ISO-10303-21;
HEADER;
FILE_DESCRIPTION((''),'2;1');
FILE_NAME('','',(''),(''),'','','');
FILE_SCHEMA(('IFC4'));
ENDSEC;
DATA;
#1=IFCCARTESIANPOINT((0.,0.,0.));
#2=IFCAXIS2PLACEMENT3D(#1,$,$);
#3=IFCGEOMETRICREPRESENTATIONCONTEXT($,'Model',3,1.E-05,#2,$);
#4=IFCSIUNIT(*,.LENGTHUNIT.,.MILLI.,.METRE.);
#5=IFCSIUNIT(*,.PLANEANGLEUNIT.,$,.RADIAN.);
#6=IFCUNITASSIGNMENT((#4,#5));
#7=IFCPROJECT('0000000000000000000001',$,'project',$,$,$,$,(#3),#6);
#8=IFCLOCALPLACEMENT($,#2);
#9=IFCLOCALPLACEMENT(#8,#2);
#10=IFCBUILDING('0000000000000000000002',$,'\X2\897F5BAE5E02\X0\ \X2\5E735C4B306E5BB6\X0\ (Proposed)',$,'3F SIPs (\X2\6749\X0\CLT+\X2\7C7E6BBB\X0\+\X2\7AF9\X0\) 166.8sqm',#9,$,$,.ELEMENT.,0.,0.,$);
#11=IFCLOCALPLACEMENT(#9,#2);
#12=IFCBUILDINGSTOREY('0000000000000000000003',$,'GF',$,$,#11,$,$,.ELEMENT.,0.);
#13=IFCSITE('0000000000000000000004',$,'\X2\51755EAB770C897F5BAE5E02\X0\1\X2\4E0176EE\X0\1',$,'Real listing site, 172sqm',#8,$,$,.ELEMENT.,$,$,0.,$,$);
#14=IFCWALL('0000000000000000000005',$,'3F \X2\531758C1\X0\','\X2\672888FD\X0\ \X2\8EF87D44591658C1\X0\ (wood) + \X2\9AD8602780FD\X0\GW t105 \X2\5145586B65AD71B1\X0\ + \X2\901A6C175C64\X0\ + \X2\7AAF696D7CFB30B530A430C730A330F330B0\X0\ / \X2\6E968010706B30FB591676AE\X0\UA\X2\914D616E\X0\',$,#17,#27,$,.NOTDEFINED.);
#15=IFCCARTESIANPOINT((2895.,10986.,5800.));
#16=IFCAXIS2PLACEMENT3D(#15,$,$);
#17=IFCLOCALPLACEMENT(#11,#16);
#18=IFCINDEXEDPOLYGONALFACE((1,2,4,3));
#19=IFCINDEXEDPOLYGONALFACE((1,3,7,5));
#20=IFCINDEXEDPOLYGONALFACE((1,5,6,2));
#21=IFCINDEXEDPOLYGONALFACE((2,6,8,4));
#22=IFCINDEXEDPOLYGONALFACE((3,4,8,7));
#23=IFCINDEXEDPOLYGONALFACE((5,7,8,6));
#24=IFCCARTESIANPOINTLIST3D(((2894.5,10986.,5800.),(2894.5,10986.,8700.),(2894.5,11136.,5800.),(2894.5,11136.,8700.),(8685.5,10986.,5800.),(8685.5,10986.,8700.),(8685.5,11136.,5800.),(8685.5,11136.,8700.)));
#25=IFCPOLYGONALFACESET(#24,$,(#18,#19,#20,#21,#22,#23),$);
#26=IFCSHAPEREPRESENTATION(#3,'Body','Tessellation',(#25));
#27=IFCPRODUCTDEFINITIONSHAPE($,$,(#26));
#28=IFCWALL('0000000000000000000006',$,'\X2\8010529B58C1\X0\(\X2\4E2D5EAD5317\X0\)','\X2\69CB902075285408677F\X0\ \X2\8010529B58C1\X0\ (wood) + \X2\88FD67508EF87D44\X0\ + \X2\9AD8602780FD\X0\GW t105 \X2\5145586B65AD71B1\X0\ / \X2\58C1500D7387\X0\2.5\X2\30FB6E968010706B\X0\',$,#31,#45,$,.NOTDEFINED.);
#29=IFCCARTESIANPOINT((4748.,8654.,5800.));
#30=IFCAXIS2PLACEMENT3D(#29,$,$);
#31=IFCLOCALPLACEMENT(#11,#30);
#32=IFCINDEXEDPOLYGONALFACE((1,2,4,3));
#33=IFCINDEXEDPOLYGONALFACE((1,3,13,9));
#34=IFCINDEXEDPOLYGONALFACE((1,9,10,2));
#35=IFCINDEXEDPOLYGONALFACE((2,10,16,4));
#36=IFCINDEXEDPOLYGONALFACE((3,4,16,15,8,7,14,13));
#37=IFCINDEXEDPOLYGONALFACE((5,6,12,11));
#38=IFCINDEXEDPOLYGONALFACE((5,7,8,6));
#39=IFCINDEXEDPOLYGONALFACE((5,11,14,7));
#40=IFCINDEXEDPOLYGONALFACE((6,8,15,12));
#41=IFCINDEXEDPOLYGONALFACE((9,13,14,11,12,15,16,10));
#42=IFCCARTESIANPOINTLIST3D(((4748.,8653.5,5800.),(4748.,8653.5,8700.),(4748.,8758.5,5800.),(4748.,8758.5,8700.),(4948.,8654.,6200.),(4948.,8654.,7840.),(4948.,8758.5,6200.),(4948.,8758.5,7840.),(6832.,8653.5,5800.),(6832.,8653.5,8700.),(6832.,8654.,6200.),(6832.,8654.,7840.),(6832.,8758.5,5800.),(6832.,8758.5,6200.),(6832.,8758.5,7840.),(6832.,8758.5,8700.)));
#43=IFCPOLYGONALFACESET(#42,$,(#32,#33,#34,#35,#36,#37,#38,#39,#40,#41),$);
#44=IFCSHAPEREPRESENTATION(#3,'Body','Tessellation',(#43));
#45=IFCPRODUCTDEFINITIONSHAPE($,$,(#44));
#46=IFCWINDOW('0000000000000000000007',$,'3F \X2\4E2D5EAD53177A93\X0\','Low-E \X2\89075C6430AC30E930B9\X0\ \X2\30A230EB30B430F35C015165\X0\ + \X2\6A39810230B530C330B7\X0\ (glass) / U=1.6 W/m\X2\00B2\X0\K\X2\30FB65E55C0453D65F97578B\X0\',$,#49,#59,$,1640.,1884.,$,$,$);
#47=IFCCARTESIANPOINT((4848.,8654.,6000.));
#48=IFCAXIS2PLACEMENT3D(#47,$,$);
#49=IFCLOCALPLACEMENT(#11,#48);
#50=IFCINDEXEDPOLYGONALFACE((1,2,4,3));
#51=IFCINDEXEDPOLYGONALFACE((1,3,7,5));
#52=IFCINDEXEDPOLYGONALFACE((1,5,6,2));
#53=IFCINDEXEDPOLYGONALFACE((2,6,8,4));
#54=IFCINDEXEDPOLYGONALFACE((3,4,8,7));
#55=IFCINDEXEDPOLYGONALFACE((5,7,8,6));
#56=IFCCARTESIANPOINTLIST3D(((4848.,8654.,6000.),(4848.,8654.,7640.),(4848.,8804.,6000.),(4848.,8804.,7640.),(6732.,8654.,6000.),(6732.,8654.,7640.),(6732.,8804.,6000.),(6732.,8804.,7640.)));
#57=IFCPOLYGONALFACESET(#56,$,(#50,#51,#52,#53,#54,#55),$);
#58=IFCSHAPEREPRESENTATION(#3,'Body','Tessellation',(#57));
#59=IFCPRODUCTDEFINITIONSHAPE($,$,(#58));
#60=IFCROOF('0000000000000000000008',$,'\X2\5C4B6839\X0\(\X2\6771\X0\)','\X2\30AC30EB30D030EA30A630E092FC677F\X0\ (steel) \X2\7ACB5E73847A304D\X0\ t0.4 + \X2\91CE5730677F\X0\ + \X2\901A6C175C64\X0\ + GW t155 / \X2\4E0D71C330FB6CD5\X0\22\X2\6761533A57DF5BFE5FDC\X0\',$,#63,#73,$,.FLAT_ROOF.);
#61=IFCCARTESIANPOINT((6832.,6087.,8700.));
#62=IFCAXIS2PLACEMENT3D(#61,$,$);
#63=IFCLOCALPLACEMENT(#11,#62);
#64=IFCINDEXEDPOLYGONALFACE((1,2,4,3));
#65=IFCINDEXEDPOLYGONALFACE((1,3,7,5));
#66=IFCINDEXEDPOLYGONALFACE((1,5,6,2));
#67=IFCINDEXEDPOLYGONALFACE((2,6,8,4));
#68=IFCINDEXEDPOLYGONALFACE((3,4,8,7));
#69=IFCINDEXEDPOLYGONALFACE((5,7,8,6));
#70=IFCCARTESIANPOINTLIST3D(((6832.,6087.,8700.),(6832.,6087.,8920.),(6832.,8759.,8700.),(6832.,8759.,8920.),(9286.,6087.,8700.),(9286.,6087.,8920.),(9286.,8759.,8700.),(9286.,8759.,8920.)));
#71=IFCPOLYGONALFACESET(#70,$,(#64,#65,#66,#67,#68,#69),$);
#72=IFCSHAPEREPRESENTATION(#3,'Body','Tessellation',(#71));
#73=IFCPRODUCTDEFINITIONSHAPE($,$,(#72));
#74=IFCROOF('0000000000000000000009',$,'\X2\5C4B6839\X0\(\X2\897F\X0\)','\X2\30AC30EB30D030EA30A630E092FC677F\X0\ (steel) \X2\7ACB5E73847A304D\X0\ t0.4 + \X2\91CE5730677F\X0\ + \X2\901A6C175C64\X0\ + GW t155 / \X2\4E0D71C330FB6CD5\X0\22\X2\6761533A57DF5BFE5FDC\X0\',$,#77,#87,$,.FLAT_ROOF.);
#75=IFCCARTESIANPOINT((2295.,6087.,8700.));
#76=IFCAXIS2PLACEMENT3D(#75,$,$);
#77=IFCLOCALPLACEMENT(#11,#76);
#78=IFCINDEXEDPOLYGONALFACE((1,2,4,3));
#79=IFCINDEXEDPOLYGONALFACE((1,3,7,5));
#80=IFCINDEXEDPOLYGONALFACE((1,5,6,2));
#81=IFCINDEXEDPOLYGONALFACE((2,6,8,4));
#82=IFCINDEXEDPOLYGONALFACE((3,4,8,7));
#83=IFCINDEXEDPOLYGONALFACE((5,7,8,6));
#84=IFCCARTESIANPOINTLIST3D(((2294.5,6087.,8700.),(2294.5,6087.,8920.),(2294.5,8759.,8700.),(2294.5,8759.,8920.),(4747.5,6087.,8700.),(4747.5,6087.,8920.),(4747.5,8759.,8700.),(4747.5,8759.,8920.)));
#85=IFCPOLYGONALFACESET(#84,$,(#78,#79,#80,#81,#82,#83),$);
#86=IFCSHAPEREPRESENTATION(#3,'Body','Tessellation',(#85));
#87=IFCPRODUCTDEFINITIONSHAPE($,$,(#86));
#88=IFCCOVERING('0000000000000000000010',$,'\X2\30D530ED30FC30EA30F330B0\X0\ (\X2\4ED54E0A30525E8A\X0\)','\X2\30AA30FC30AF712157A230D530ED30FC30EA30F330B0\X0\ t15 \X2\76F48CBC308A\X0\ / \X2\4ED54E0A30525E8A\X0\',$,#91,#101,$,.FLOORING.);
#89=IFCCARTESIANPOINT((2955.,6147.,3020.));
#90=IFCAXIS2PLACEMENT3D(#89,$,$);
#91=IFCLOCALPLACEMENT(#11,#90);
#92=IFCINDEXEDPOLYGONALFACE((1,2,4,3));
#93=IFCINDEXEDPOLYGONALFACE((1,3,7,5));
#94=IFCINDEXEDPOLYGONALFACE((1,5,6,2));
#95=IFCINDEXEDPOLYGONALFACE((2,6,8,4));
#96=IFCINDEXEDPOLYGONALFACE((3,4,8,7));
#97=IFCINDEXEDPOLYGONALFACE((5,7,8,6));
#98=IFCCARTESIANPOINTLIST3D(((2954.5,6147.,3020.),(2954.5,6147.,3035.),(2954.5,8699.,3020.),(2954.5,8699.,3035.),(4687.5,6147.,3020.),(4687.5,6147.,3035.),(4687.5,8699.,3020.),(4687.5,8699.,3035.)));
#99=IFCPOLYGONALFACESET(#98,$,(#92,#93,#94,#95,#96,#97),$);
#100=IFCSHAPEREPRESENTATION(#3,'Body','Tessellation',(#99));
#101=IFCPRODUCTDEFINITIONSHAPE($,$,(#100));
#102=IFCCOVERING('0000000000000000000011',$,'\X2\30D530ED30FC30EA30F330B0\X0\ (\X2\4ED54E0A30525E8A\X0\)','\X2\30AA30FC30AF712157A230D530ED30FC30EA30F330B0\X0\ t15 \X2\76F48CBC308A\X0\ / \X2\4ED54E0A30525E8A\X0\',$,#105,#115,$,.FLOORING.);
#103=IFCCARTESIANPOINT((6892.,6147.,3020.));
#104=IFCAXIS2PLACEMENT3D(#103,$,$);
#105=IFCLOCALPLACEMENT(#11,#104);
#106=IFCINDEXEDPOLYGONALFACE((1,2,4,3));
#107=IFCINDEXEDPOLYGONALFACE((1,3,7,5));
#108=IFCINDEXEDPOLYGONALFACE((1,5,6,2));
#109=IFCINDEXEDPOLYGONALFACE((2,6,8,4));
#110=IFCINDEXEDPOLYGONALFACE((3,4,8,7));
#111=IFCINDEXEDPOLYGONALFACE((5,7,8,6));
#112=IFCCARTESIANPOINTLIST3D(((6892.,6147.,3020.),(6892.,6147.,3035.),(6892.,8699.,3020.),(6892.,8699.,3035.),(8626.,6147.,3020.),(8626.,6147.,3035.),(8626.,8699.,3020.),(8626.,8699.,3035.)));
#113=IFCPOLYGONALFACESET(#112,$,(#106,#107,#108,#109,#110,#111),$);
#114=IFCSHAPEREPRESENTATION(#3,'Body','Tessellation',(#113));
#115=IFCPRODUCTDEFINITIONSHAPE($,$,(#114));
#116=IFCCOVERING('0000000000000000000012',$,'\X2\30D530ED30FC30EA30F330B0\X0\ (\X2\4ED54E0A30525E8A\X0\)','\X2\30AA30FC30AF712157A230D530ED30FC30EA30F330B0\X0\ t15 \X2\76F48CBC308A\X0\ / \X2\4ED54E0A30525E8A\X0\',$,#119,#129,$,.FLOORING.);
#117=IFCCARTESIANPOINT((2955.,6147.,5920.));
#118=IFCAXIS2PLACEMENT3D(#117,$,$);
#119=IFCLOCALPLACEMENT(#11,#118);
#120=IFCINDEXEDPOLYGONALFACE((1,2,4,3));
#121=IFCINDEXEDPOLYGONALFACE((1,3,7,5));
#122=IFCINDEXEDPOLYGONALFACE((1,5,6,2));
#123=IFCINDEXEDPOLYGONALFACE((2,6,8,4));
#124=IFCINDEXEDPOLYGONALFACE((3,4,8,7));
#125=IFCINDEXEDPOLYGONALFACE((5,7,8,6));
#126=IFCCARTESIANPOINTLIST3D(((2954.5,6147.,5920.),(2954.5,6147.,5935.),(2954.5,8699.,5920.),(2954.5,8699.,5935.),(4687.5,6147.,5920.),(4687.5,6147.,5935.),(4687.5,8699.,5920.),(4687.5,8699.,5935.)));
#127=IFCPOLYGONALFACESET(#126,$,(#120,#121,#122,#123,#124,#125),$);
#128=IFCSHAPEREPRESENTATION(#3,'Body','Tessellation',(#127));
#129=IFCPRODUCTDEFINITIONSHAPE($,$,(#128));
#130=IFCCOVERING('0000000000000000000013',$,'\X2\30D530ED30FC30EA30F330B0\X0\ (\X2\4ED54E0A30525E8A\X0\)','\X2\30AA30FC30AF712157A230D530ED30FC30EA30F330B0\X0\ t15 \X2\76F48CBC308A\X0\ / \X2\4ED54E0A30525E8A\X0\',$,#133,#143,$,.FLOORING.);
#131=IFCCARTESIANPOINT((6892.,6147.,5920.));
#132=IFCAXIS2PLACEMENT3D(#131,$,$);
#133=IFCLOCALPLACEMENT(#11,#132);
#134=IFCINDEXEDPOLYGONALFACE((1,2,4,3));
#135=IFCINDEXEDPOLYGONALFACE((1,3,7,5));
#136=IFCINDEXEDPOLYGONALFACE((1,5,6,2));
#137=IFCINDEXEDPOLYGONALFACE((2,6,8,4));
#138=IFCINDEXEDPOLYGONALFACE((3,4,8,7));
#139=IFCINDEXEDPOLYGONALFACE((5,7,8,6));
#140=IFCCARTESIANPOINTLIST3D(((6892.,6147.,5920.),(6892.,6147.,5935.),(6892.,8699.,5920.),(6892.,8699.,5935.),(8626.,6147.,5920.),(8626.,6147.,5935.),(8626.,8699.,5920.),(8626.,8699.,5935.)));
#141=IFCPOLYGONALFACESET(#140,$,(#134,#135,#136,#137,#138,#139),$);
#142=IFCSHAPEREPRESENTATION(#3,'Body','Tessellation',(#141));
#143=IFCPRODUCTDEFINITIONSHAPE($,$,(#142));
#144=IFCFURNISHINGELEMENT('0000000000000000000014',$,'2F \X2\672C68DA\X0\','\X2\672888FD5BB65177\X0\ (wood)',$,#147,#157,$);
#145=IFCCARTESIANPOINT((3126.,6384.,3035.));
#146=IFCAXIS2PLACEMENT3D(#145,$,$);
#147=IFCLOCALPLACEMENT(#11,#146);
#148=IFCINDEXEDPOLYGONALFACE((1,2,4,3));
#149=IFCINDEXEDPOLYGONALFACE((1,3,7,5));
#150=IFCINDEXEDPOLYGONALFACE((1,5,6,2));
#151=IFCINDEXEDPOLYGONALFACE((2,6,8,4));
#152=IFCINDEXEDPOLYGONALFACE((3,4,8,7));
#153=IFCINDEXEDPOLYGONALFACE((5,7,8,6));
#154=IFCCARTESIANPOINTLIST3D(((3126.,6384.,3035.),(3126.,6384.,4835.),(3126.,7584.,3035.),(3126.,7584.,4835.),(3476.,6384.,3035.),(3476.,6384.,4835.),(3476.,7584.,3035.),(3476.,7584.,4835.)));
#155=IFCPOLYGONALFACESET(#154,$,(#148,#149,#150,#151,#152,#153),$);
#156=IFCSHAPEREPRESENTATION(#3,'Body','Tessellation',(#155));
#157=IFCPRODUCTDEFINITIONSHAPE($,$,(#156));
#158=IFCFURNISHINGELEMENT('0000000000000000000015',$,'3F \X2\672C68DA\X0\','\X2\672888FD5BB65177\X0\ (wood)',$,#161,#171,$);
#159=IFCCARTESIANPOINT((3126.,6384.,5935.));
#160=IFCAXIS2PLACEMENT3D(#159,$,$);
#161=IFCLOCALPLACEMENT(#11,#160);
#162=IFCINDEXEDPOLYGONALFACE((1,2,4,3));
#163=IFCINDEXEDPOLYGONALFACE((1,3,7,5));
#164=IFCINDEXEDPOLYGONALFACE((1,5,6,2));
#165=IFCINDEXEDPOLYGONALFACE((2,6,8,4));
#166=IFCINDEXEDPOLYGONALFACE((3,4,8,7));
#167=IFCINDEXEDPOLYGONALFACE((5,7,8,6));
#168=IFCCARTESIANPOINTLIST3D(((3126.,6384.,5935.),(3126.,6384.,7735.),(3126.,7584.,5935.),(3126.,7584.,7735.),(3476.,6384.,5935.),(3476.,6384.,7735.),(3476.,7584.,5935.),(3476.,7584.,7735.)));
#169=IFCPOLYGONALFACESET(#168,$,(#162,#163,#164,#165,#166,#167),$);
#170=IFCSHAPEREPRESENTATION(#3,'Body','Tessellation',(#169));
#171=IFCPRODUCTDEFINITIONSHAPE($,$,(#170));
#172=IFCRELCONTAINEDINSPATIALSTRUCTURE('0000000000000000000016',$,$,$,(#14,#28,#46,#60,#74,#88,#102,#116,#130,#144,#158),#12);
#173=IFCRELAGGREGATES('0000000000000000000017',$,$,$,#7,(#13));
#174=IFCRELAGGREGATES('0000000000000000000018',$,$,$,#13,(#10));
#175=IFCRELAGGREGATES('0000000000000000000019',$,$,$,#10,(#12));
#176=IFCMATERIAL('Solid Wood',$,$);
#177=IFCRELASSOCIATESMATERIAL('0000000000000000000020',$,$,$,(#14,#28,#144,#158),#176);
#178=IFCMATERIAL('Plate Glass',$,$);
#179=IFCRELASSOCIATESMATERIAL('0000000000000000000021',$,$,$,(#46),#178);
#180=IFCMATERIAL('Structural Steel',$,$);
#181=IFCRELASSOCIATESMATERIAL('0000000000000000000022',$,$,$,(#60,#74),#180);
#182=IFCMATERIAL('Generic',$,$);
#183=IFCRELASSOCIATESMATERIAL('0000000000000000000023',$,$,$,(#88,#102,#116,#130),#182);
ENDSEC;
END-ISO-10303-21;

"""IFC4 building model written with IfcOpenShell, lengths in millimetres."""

from ifc_helpers import new_model, si_unit, frame, frame_2d, origin, place, context, project, spatial, rectangle, extrude, material, element, fill, save


model = new_model("IFC4")

# Units and contexts
model_context = context("Model", 3, precision=1e-05, world=origin())
ifc_project = project(units=[si_unit("LENGTHUNIT", "METRE", prefix="MILLI"), si_unit("PLANEANGLEUNIT", "RADIAN")], contexts=[model_context])

# Site, building, storey
site_placement = place(None, origin())
site = spatial("IfcSite", under=ifc_project, at=site_placement, Name="兵庫県西宮市1丁目1", ObjectType="Real listing site, 172sqm", CompositionType="ELEMENT", RefElevation=0.0)
building_placement = place(site_placement, origin())
building = spatial("IfcBuilding", under=site, at=building_placement, Name="西宮市 平屋の家 (Proposed)", ObjectType="3F SIPs (杉CLT+籾殻+竹) 166.8sqm", CompositionType="ELEMENT", ElevationOfRefHeight=0.0, ElevationOfTerrain=0.0)
storey_placement = place(building_placement, origin())
storey = spatial("IfcBuildingStorey", under=building, at=storey_placement, Name="GF", CompositionType="ELEMENT", Elevation=0.0)

# Shared definitions
ifc_material_1 = material(Name="Solid Wood")

# Wall
wall_1_placement = place(storey_placement, frame((2895.0, 10986.0, 5800.0)))
element("IfcWall", 1, at=wall_1_placement, inside=storey, material=ifc_material_1, Name="3F 北壁", Description="木製 軸組外壁 (wood) + 高性能GW t105 充填断熱 + 通気層 + 窯業系サイディング / 準耐火・外皮UA配慮", PredefinedType="NOTDEFINED", context=model_context, shape_type="SweptSolid", body=[
    extrude(rectangle(XDim=5791.0, YDim=150.0, at=frame_2d((2895.0, 75.0))), frame((2895.0, 10986.0, 5800.0)), (0.0, 0.0, 1.0), 2900.0),
])

# Wall, opening, window
wall_2_placement = place(storey_placement, frame((4748.0, 8654.0, 5800.0)))
wall_2 = element("IfcWall", 2, at=wall_2_placement, inside=storey, material=ifc_material_1, Name="耐力壁(中庭北)", Description="構造用合板 耐力壁 (wood) + 製材軸組 + 高性能GW t105 充填断熱 / 壁倍率2.5・準耐火", PredefinedType="NOTDEFINED", context=model_context, shape_type="SweptSolid", body=[
    extrude(rectangle(XDim=2084.0, YDim=105.0, at=frame_2d((1042.0, 52.0))), frame((4748.0, 8654.0, 5800.0)), (0.0, 0.0, 1.0), 2900.0),
])
opening_placement = place(storey_placement, frame((4848.0, 8654.0, 6000.0)))
opening = element("IfcOpeningElement", 3, at=opening_placement, cuts=wall_2, PredefinedType="NOTDEFINED", context=model_context, shape_type="SweptSolid", body=[
    extrude(rectangle(XDim=1884.0, YDim=150.0, at=frame_2d((942.0, 75.0))), frame((4848.0, 8654.0, 6000.0)), (0.0, 0.0, 1.0), 1640.0),
])
ifc_material_2 = material(Name="Plate Glass")
window_1_placement = place(storey_placement, frame((4848.0, 8654.0, 6000.0)))
window_1 = element("IfcWindow", 4, at=window_1_placement, inside=storey, material=ifc_material_2, Name="3F 中庭北窓", Description="Low-E 複層ガラス アルゴン封入 + 樹脂サッシ (glass) / U=1.6 W/m²K・日射取得型", OverallHeight=1640.0, OverallWidth=1884.0, context=model_context, shape_type="SweptSolid", body=[
    extrude(rectangle(XDim=1884.0, YDim=150.0, at=frame_2d((942.0, 75.0))), frame((4848.0, 8654.0, 6000.0)), (0.0, 0.0, 1.0), 1640.0),
])
fill(opening, window_1)

# Shared definitions
ifc_material_3 = material(Name="Generic")

# Roofs
ifc_material_4 = material(Name="Structural Steel")
roof_1_placement = place(storey_placement, frame((6832.0, 6087.0, 8700.0)))
element("IfcRoof", 5, at=roof_1_placement, inside=storey, material=ifc_material_4, Name="屋根(東)", Description="ガルバリウム鋼板 (steel) 立平葺き t0.4 + 野地板 + 通気層 + GW t155 / 不燃・法22条区域対応", PredefinedType="FLAT_ROOF", context=model_context, shape_type="SweptSolid", body=[
    extrude(rectangle(XDim=2454.0, YDim=2672.0, at=frame_2d((1227.0, 1336.0))), frame((6832.0, 6087.0, 8700.0)), (0.0, 0.0, 1.0), 220.0),
])
roof_2_placement = place(storey_placement, frame((2295.0, 6087.0, 8700.0)))
element("IfcRoof", 6, at=roof_2_placement, inside=storey, material=ifc_material_4, Name="屋根(西)", Description="ガルバリウム鋼板 (steel) 立平葺き t0.4 + 野地板 + 通気層 + GW t155 / 不燃・法22条区域対応", PredefinedType="FLAT_ROOF", context=model_context, shape_type="SweptSolid", body=[
    extrude(rectangle(XDim=2453.0, YDim=2672.0, at=frame_2d((1226.0, 1336.0))), frame((2295.0, 6087.0, 8700.0)), (0.0, 0.0, 1.0), 220.0),
])

# Coverings
covering_1_placement = place(storey_placement, frame((2955.0, 6147.0, 3020.0)))
element("IfcCovering", 7, at=covering_1_placement, inside=storey, material=ifc_material_3, Name="フローリング (仕上げ床)", Description="オーク無垢フローリング t15 直貼り / 仕上げ床", PredefinedType="FLOORING", context=model_context, shape_type="SweptSolid", body=[
    extrude(rectangle(XDim=1733.0, YDim=2552.0, at=frame_2d((866.0, 1276.0))), frame((2955.0, 6147.0, 3020.0)), (0.0, 0.0, 1.0), 15.0),
])
covering_2_placement = place(storey_placement, frame((6892.0, 6147.0, 3020.0)))
element("IfcCovering", 8, at=covering_2_placement, inside=storey, material=ifc_material_3, Name="フローリング (仕上げ床)", Description="オーク無垢フローリング t15 直貼り / 仕上げ床", PredefinedType="FLOORING", context=model_context, shape_type="SweptSolid", body=[
    extrude(rectangle(XDim=1734.0, YDim=2552.0, at=frame_2d((867.0, 1276.0))), frame((6892.0, 6147.0, 3020.0)), (0.0, 0.0, 1.0), 15.0),
])
covering_3_placement = place(storey_placement, frame((2955.0, 6147.0, 5920.0)))
element("IfcCovering", 9, at=covering_3_placement, inside=storey, material=ifc_material_3, Name="フローリング (仕上げ床)", Description="オーク無垢フローリング t15 直貼り / 仕上げ床", PredefinedType="FLOORING", context=model_context, shape_type="SweptSolid", body=[
    extrude(rectangle(XDim=1733.0, YDim=2552.0, at=frame_2d((866.0, 1276.0))), frame((2955.0, 6147.0, 5920.0)), (0.0, 0.0, 1.0), 15.0),
])
covering_4_placement = place(storey_placement, frame((6892.0, 6147.0, 5920.0)))
element("IfcCovering", 10, at=covering_4_placement, inside=storey, material=ifc_material_3, Name="フローリング (仕上げ床)", Description="オーク無垢フローリング t15 直貼り / 仕上げ床", PredefinedType="FLOORING", context=model_context, shape_type="SweptSolid", body=[
    extrude(rectangle(XDim=1734.0, YDim=2552.0, at=frame_2d((867.0, 1276.0))), frame((6892.0, 6147.0, 5920.0)), (0.0, 0.0, 1.0), 15.0),
])

# Furnishing elements
furnishing_1_placement = place(storey_placement, frame((3126.0, 6384.0, 3035.0)))
element("IfcFurnishingElement", 11, at=furnishing_1_placement, inside=storey, material=ifc_material_1, Name="2F 本棚", Description="木製家具 (wood)", context=model_context, shape_type="SweptSolid", body=[
    extrude(rectangle(XDim=350.0, YDim=1200.0, at=frame_2d((175.0, 600.0))), frame((3126.0, 6384.0, 3035.0)), (0.0, 0.0, 1.0), 1800.0),
])
furnishing_2_placement = place(storey_placement, frame((3126.0, 6384.0, 5935.0)))
element("IfcFurnishingElement", 12, at=furnishing_2_placement, inside=storey, material=ifc_material_1, Name="3F 本棚", Description="木製家具 (wood)", context=model_context, shape_type="SweptSolid", body=[
    extrude(rectangle(XDim=350.0, YDim=1200.0, at=frame_2d((175.0, 600.0))), frame((3126.0, 6384.0, 5935.0)), (0.0, 0.0, 1.0), 1800.0),
])

save(model, "model.ifc")
